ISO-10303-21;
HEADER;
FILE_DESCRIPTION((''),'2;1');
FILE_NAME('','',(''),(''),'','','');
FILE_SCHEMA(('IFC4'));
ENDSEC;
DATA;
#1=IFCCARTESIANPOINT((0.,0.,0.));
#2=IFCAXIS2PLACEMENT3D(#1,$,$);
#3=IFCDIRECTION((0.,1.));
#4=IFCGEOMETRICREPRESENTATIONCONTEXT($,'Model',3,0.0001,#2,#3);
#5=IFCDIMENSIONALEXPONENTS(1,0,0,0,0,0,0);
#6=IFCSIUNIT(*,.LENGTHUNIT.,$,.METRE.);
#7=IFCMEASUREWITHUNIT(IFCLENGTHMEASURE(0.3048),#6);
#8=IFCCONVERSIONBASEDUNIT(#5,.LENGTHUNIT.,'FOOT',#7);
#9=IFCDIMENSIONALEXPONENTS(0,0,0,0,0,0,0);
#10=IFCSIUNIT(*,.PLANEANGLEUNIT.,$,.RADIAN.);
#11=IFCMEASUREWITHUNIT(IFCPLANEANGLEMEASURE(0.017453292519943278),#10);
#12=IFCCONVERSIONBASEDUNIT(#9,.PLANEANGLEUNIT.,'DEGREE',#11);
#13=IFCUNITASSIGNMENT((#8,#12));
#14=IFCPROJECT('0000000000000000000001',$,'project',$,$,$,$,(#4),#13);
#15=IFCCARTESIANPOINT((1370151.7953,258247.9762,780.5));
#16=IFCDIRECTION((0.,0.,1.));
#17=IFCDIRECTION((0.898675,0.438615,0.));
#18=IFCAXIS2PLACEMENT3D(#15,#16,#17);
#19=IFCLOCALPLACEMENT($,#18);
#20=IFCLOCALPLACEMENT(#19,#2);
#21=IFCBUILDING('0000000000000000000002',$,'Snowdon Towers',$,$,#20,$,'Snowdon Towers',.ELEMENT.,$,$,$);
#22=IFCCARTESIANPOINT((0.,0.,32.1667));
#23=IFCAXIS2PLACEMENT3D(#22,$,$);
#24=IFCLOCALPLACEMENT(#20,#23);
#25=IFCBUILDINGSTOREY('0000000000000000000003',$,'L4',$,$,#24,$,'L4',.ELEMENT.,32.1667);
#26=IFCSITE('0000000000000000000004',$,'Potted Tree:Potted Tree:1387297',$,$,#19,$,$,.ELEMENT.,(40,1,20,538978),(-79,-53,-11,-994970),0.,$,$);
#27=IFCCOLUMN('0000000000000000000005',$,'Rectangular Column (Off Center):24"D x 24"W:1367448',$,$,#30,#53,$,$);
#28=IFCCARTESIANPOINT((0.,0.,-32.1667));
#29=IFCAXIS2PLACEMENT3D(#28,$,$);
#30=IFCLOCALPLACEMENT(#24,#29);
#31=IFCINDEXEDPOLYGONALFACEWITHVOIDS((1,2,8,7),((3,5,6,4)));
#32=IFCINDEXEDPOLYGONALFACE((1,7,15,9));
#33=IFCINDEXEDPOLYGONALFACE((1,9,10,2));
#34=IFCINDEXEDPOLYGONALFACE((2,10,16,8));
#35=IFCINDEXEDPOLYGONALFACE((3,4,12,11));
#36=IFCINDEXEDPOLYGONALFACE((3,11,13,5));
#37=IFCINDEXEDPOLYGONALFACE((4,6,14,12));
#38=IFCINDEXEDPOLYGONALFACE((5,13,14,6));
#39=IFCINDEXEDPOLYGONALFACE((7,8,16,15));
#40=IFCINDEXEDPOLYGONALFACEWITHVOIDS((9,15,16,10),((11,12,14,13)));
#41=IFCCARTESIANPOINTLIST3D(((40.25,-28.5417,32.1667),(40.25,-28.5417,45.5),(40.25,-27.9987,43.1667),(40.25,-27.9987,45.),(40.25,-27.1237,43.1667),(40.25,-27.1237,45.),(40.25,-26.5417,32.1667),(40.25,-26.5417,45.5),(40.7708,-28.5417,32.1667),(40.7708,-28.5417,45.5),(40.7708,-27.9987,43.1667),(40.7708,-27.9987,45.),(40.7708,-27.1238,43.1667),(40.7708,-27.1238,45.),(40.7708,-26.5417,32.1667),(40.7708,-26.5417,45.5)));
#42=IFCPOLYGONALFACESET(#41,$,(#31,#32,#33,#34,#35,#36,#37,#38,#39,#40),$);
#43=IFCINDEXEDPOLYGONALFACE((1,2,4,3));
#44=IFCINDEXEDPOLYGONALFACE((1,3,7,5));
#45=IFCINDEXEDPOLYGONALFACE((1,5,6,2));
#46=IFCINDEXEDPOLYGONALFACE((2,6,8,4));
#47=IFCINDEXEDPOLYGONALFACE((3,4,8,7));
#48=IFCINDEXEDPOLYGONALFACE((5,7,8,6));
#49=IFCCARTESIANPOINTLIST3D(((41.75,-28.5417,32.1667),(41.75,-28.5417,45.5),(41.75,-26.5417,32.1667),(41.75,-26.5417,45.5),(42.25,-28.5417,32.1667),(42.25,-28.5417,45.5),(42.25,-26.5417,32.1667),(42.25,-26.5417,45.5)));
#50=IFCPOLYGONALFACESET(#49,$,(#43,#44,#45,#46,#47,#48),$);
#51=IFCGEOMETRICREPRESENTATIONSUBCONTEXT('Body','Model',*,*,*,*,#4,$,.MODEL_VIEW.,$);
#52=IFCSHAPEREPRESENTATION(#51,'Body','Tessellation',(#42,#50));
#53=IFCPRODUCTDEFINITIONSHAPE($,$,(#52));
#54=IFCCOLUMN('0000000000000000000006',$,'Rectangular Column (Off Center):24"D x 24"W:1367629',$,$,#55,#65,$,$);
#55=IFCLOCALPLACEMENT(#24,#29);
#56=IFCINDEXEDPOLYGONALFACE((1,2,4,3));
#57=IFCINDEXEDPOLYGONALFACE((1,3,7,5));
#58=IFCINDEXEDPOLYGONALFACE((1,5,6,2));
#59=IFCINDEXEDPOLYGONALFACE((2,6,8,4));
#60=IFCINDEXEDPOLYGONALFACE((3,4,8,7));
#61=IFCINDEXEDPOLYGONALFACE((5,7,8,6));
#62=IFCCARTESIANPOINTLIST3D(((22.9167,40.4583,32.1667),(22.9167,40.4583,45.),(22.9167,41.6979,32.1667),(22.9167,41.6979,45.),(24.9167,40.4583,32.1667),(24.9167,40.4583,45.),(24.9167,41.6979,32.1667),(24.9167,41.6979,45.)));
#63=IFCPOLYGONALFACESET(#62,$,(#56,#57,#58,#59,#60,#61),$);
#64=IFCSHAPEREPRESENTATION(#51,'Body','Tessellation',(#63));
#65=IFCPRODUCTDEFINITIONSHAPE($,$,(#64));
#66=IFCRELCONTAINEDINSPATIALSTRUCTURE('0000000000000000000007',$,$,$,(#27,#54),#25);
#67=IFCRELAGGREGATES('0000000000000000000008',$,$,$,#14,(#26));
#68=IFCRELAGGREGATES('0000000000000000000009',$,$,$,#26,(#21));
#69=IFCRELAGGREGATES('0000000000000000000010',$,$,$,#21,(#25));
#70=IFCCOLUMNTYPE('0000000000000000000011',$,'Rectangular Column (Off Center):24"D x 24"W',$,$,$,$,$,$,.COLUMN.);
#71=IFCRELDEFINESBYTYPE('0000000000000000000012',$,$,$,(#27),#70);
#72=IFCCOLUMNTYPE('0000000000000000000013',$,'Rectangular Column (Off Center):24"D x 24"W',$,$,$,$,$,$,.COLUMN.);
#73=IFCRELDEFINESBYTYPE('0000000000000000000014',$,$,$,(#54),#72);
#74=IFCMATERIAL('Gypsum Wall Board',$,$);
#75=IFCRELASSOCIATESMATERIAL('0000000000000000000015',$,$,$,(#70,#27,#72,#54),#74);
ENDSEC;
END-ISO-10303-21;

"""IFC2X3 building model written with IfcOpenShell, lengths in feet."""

from ifc_helpers import new_model, entity, si_unit, converted_unit, direction, frame, frame_2d, origin, place, context, subcontext, project, spatial, rectangle, extrude, source, transform, mapped, material, type_object, type_shapes, element, save


model = new_model("IFC2X3")

# Units and contexts
model_context = context("Model", 3, precision=0.0001, world=origin(), true_north=direction((0.0, 1.0)))
body_context = subcontext(model_context, "Body", "Model", "MODEL_VIEW")
ifc_project = project(units=[converted_unit("LENGTHUNIT", "FOOT", entity("IfcLengthMeasure", 0.3048), si_unit("LENGTHUNIT", "METRE"), dimensions=[1, 0, 0, 0, 0, 0, 0]), converted_unit("PLANEANGLEUNIT", "DEGREE", entity("IfcPlaneAngleMeasure", 0.017453292519943278), si_unit("PLANEANGLEUNIT", "RADIAN"), dimensions=[0, 0, 0, 0, 0, 0, 0])], contexts=[model_context])

# Site, building, storey
site_placement = place(None, frame((1370151.7953, 258247.9762, 780.5), z_axis=(0.0, 0.0, 1.0), x_axis=(0.898675, 0.438615, 0.0)))
site = spatial("IfcSite", under=ifc_project, at=site_placement, Name="Potted Tree:Potted Tree:1387297", CompositionType="ELEMENT", RefLatitude=(40, 1, 20, 538978), RefLongitude=(-79, -53, -11, -994970), RefElevation=0.0)
building_placement = place(site_placement, origin())
building = spatial("IfcBuilding", under=site, at=building_placement, Name="Snowdon Towers", LongName="Snowdon Towers", CompositionType="ELEMENT")
storey_placement = place(building_placement, frame((0.0, 0.0, 32.1667)))
storey = spatial("IfcBuildingStorey", under=building, at=storey_placement, Name="L4", LongName="L4", CompositionType="ELEMENT", Elevation=32.1667)

# Shared definitions
ifc_material = material(Name="Gypsum Wall Board")

# Column, opening
column_type_1 = type_object("IfcColumnType", Name="Rectangular Column (Off Center):24\"D x 24\"W", PredefinedType="COLUMN", material=ifc_material)
shared_shape_1 = source(origin(), body_context, "Body", "SweptSolid", [
    extrude(rectangle(XDim=2.0, YDim=0.5208, at=frame_2d((0.0, 0.0), x_axis=(1.0, 0.0))), frame((40.5104, -27.5417, 32.1667), z_axis=(0.0, 0.0, 1.0), x_axis=(0.0, -1.0, 0.0)), (0.0, 0.0, 1.0), 13.3333),
    extrude(rectangle(XDim=0.5, YDim=2.0, at=frame_2d((-0.0021, -0.2), x_axis=(1.0, 0.0))), frame((41.9979, -27.7417, 32.1667), z_axis=(0.0, 0.0, 1.0), x_axis=(-1.0, 0.0, 0.0)), (0.0, 0.0, 1.0), 13.3333),
])
type_shapes(column_type_1, [shared_shape_1])
column_1_placement = place(storey_placement, frame((0.0, 0.0, -32.1667)))
column_1 = element("IfcColumn", 1, at=column_1_placement, inside=storey, type_object=column_type_1, material=ifc_material, Name="Rectangular Column (Off Center):24\"D x 24\"W:1367448", context=body_context, shape_type="MappedRepresentation", body=[
    mapped(shared_shape_1, transform((0.0, 0.0, 0.0), scale=1.0)),
])
opening_1_placement = place(storey_placement, frame((0.0, 0.0, -32.1667)))
element("IfcOpeningElement", 2, at=opening_1_placement, cuts=column_1, ObjectType="Opening", context=body_context, shape_type="SweptSolid", body=[
    extrude(rectangle(XDim=1.8333, YDim=0.875, at=frame_2d((0.0, 0.0), x_axis=(1.0, 0.0))), frame((40.25, -27.5613, 44.0833), z_axis=(1.0, 0.0, 0.0), x_axis=(0.0, 0.0, -1.0)), (0.0, 0.0, 1.0), 0.5208),
])

# Column
column_type_2 = type_object("IfcColumnType", Name="Rectangular Column (Off Center):24\"D x 24\"W", PredefinedType="COLUMN", material=ifc_material)
shared_shape_2 = source(origin(), body_context, "Body", "SweptSolid", [
    extrude(rectangle(XDim=1.2396, YDim=2.0, at=frame_2d((0.0, 0.0), x_axis=(1.0, 0.0))), frame((23.9167, 41.0781, 32.1667), z_axis=(0.0, 0.0, 1.0), x_axis=(0.0, 1.0, 0.0)), (0.0, 0.0, 1.0), 12.8333),
])
type_shapes(column_type_2, [shared_shape_2])
column_2_placement = place(storey_placement, frame((0.0, 0.0, -32.1667)))
element("IfcColumn", 3, at=column_2_placement, inside=storey, type_object=column_type_2, material=ifc_material, Name="Rectangular Column (Off Center):24\"D x 24\"W:1367629", context=body_context, shape_type="MappedRepresentation", body=[
    mapped(shared_shape_2, transform((0.0, 0.0, 0.0), scale=1.0)),
])

save(model, "model.ifc")
